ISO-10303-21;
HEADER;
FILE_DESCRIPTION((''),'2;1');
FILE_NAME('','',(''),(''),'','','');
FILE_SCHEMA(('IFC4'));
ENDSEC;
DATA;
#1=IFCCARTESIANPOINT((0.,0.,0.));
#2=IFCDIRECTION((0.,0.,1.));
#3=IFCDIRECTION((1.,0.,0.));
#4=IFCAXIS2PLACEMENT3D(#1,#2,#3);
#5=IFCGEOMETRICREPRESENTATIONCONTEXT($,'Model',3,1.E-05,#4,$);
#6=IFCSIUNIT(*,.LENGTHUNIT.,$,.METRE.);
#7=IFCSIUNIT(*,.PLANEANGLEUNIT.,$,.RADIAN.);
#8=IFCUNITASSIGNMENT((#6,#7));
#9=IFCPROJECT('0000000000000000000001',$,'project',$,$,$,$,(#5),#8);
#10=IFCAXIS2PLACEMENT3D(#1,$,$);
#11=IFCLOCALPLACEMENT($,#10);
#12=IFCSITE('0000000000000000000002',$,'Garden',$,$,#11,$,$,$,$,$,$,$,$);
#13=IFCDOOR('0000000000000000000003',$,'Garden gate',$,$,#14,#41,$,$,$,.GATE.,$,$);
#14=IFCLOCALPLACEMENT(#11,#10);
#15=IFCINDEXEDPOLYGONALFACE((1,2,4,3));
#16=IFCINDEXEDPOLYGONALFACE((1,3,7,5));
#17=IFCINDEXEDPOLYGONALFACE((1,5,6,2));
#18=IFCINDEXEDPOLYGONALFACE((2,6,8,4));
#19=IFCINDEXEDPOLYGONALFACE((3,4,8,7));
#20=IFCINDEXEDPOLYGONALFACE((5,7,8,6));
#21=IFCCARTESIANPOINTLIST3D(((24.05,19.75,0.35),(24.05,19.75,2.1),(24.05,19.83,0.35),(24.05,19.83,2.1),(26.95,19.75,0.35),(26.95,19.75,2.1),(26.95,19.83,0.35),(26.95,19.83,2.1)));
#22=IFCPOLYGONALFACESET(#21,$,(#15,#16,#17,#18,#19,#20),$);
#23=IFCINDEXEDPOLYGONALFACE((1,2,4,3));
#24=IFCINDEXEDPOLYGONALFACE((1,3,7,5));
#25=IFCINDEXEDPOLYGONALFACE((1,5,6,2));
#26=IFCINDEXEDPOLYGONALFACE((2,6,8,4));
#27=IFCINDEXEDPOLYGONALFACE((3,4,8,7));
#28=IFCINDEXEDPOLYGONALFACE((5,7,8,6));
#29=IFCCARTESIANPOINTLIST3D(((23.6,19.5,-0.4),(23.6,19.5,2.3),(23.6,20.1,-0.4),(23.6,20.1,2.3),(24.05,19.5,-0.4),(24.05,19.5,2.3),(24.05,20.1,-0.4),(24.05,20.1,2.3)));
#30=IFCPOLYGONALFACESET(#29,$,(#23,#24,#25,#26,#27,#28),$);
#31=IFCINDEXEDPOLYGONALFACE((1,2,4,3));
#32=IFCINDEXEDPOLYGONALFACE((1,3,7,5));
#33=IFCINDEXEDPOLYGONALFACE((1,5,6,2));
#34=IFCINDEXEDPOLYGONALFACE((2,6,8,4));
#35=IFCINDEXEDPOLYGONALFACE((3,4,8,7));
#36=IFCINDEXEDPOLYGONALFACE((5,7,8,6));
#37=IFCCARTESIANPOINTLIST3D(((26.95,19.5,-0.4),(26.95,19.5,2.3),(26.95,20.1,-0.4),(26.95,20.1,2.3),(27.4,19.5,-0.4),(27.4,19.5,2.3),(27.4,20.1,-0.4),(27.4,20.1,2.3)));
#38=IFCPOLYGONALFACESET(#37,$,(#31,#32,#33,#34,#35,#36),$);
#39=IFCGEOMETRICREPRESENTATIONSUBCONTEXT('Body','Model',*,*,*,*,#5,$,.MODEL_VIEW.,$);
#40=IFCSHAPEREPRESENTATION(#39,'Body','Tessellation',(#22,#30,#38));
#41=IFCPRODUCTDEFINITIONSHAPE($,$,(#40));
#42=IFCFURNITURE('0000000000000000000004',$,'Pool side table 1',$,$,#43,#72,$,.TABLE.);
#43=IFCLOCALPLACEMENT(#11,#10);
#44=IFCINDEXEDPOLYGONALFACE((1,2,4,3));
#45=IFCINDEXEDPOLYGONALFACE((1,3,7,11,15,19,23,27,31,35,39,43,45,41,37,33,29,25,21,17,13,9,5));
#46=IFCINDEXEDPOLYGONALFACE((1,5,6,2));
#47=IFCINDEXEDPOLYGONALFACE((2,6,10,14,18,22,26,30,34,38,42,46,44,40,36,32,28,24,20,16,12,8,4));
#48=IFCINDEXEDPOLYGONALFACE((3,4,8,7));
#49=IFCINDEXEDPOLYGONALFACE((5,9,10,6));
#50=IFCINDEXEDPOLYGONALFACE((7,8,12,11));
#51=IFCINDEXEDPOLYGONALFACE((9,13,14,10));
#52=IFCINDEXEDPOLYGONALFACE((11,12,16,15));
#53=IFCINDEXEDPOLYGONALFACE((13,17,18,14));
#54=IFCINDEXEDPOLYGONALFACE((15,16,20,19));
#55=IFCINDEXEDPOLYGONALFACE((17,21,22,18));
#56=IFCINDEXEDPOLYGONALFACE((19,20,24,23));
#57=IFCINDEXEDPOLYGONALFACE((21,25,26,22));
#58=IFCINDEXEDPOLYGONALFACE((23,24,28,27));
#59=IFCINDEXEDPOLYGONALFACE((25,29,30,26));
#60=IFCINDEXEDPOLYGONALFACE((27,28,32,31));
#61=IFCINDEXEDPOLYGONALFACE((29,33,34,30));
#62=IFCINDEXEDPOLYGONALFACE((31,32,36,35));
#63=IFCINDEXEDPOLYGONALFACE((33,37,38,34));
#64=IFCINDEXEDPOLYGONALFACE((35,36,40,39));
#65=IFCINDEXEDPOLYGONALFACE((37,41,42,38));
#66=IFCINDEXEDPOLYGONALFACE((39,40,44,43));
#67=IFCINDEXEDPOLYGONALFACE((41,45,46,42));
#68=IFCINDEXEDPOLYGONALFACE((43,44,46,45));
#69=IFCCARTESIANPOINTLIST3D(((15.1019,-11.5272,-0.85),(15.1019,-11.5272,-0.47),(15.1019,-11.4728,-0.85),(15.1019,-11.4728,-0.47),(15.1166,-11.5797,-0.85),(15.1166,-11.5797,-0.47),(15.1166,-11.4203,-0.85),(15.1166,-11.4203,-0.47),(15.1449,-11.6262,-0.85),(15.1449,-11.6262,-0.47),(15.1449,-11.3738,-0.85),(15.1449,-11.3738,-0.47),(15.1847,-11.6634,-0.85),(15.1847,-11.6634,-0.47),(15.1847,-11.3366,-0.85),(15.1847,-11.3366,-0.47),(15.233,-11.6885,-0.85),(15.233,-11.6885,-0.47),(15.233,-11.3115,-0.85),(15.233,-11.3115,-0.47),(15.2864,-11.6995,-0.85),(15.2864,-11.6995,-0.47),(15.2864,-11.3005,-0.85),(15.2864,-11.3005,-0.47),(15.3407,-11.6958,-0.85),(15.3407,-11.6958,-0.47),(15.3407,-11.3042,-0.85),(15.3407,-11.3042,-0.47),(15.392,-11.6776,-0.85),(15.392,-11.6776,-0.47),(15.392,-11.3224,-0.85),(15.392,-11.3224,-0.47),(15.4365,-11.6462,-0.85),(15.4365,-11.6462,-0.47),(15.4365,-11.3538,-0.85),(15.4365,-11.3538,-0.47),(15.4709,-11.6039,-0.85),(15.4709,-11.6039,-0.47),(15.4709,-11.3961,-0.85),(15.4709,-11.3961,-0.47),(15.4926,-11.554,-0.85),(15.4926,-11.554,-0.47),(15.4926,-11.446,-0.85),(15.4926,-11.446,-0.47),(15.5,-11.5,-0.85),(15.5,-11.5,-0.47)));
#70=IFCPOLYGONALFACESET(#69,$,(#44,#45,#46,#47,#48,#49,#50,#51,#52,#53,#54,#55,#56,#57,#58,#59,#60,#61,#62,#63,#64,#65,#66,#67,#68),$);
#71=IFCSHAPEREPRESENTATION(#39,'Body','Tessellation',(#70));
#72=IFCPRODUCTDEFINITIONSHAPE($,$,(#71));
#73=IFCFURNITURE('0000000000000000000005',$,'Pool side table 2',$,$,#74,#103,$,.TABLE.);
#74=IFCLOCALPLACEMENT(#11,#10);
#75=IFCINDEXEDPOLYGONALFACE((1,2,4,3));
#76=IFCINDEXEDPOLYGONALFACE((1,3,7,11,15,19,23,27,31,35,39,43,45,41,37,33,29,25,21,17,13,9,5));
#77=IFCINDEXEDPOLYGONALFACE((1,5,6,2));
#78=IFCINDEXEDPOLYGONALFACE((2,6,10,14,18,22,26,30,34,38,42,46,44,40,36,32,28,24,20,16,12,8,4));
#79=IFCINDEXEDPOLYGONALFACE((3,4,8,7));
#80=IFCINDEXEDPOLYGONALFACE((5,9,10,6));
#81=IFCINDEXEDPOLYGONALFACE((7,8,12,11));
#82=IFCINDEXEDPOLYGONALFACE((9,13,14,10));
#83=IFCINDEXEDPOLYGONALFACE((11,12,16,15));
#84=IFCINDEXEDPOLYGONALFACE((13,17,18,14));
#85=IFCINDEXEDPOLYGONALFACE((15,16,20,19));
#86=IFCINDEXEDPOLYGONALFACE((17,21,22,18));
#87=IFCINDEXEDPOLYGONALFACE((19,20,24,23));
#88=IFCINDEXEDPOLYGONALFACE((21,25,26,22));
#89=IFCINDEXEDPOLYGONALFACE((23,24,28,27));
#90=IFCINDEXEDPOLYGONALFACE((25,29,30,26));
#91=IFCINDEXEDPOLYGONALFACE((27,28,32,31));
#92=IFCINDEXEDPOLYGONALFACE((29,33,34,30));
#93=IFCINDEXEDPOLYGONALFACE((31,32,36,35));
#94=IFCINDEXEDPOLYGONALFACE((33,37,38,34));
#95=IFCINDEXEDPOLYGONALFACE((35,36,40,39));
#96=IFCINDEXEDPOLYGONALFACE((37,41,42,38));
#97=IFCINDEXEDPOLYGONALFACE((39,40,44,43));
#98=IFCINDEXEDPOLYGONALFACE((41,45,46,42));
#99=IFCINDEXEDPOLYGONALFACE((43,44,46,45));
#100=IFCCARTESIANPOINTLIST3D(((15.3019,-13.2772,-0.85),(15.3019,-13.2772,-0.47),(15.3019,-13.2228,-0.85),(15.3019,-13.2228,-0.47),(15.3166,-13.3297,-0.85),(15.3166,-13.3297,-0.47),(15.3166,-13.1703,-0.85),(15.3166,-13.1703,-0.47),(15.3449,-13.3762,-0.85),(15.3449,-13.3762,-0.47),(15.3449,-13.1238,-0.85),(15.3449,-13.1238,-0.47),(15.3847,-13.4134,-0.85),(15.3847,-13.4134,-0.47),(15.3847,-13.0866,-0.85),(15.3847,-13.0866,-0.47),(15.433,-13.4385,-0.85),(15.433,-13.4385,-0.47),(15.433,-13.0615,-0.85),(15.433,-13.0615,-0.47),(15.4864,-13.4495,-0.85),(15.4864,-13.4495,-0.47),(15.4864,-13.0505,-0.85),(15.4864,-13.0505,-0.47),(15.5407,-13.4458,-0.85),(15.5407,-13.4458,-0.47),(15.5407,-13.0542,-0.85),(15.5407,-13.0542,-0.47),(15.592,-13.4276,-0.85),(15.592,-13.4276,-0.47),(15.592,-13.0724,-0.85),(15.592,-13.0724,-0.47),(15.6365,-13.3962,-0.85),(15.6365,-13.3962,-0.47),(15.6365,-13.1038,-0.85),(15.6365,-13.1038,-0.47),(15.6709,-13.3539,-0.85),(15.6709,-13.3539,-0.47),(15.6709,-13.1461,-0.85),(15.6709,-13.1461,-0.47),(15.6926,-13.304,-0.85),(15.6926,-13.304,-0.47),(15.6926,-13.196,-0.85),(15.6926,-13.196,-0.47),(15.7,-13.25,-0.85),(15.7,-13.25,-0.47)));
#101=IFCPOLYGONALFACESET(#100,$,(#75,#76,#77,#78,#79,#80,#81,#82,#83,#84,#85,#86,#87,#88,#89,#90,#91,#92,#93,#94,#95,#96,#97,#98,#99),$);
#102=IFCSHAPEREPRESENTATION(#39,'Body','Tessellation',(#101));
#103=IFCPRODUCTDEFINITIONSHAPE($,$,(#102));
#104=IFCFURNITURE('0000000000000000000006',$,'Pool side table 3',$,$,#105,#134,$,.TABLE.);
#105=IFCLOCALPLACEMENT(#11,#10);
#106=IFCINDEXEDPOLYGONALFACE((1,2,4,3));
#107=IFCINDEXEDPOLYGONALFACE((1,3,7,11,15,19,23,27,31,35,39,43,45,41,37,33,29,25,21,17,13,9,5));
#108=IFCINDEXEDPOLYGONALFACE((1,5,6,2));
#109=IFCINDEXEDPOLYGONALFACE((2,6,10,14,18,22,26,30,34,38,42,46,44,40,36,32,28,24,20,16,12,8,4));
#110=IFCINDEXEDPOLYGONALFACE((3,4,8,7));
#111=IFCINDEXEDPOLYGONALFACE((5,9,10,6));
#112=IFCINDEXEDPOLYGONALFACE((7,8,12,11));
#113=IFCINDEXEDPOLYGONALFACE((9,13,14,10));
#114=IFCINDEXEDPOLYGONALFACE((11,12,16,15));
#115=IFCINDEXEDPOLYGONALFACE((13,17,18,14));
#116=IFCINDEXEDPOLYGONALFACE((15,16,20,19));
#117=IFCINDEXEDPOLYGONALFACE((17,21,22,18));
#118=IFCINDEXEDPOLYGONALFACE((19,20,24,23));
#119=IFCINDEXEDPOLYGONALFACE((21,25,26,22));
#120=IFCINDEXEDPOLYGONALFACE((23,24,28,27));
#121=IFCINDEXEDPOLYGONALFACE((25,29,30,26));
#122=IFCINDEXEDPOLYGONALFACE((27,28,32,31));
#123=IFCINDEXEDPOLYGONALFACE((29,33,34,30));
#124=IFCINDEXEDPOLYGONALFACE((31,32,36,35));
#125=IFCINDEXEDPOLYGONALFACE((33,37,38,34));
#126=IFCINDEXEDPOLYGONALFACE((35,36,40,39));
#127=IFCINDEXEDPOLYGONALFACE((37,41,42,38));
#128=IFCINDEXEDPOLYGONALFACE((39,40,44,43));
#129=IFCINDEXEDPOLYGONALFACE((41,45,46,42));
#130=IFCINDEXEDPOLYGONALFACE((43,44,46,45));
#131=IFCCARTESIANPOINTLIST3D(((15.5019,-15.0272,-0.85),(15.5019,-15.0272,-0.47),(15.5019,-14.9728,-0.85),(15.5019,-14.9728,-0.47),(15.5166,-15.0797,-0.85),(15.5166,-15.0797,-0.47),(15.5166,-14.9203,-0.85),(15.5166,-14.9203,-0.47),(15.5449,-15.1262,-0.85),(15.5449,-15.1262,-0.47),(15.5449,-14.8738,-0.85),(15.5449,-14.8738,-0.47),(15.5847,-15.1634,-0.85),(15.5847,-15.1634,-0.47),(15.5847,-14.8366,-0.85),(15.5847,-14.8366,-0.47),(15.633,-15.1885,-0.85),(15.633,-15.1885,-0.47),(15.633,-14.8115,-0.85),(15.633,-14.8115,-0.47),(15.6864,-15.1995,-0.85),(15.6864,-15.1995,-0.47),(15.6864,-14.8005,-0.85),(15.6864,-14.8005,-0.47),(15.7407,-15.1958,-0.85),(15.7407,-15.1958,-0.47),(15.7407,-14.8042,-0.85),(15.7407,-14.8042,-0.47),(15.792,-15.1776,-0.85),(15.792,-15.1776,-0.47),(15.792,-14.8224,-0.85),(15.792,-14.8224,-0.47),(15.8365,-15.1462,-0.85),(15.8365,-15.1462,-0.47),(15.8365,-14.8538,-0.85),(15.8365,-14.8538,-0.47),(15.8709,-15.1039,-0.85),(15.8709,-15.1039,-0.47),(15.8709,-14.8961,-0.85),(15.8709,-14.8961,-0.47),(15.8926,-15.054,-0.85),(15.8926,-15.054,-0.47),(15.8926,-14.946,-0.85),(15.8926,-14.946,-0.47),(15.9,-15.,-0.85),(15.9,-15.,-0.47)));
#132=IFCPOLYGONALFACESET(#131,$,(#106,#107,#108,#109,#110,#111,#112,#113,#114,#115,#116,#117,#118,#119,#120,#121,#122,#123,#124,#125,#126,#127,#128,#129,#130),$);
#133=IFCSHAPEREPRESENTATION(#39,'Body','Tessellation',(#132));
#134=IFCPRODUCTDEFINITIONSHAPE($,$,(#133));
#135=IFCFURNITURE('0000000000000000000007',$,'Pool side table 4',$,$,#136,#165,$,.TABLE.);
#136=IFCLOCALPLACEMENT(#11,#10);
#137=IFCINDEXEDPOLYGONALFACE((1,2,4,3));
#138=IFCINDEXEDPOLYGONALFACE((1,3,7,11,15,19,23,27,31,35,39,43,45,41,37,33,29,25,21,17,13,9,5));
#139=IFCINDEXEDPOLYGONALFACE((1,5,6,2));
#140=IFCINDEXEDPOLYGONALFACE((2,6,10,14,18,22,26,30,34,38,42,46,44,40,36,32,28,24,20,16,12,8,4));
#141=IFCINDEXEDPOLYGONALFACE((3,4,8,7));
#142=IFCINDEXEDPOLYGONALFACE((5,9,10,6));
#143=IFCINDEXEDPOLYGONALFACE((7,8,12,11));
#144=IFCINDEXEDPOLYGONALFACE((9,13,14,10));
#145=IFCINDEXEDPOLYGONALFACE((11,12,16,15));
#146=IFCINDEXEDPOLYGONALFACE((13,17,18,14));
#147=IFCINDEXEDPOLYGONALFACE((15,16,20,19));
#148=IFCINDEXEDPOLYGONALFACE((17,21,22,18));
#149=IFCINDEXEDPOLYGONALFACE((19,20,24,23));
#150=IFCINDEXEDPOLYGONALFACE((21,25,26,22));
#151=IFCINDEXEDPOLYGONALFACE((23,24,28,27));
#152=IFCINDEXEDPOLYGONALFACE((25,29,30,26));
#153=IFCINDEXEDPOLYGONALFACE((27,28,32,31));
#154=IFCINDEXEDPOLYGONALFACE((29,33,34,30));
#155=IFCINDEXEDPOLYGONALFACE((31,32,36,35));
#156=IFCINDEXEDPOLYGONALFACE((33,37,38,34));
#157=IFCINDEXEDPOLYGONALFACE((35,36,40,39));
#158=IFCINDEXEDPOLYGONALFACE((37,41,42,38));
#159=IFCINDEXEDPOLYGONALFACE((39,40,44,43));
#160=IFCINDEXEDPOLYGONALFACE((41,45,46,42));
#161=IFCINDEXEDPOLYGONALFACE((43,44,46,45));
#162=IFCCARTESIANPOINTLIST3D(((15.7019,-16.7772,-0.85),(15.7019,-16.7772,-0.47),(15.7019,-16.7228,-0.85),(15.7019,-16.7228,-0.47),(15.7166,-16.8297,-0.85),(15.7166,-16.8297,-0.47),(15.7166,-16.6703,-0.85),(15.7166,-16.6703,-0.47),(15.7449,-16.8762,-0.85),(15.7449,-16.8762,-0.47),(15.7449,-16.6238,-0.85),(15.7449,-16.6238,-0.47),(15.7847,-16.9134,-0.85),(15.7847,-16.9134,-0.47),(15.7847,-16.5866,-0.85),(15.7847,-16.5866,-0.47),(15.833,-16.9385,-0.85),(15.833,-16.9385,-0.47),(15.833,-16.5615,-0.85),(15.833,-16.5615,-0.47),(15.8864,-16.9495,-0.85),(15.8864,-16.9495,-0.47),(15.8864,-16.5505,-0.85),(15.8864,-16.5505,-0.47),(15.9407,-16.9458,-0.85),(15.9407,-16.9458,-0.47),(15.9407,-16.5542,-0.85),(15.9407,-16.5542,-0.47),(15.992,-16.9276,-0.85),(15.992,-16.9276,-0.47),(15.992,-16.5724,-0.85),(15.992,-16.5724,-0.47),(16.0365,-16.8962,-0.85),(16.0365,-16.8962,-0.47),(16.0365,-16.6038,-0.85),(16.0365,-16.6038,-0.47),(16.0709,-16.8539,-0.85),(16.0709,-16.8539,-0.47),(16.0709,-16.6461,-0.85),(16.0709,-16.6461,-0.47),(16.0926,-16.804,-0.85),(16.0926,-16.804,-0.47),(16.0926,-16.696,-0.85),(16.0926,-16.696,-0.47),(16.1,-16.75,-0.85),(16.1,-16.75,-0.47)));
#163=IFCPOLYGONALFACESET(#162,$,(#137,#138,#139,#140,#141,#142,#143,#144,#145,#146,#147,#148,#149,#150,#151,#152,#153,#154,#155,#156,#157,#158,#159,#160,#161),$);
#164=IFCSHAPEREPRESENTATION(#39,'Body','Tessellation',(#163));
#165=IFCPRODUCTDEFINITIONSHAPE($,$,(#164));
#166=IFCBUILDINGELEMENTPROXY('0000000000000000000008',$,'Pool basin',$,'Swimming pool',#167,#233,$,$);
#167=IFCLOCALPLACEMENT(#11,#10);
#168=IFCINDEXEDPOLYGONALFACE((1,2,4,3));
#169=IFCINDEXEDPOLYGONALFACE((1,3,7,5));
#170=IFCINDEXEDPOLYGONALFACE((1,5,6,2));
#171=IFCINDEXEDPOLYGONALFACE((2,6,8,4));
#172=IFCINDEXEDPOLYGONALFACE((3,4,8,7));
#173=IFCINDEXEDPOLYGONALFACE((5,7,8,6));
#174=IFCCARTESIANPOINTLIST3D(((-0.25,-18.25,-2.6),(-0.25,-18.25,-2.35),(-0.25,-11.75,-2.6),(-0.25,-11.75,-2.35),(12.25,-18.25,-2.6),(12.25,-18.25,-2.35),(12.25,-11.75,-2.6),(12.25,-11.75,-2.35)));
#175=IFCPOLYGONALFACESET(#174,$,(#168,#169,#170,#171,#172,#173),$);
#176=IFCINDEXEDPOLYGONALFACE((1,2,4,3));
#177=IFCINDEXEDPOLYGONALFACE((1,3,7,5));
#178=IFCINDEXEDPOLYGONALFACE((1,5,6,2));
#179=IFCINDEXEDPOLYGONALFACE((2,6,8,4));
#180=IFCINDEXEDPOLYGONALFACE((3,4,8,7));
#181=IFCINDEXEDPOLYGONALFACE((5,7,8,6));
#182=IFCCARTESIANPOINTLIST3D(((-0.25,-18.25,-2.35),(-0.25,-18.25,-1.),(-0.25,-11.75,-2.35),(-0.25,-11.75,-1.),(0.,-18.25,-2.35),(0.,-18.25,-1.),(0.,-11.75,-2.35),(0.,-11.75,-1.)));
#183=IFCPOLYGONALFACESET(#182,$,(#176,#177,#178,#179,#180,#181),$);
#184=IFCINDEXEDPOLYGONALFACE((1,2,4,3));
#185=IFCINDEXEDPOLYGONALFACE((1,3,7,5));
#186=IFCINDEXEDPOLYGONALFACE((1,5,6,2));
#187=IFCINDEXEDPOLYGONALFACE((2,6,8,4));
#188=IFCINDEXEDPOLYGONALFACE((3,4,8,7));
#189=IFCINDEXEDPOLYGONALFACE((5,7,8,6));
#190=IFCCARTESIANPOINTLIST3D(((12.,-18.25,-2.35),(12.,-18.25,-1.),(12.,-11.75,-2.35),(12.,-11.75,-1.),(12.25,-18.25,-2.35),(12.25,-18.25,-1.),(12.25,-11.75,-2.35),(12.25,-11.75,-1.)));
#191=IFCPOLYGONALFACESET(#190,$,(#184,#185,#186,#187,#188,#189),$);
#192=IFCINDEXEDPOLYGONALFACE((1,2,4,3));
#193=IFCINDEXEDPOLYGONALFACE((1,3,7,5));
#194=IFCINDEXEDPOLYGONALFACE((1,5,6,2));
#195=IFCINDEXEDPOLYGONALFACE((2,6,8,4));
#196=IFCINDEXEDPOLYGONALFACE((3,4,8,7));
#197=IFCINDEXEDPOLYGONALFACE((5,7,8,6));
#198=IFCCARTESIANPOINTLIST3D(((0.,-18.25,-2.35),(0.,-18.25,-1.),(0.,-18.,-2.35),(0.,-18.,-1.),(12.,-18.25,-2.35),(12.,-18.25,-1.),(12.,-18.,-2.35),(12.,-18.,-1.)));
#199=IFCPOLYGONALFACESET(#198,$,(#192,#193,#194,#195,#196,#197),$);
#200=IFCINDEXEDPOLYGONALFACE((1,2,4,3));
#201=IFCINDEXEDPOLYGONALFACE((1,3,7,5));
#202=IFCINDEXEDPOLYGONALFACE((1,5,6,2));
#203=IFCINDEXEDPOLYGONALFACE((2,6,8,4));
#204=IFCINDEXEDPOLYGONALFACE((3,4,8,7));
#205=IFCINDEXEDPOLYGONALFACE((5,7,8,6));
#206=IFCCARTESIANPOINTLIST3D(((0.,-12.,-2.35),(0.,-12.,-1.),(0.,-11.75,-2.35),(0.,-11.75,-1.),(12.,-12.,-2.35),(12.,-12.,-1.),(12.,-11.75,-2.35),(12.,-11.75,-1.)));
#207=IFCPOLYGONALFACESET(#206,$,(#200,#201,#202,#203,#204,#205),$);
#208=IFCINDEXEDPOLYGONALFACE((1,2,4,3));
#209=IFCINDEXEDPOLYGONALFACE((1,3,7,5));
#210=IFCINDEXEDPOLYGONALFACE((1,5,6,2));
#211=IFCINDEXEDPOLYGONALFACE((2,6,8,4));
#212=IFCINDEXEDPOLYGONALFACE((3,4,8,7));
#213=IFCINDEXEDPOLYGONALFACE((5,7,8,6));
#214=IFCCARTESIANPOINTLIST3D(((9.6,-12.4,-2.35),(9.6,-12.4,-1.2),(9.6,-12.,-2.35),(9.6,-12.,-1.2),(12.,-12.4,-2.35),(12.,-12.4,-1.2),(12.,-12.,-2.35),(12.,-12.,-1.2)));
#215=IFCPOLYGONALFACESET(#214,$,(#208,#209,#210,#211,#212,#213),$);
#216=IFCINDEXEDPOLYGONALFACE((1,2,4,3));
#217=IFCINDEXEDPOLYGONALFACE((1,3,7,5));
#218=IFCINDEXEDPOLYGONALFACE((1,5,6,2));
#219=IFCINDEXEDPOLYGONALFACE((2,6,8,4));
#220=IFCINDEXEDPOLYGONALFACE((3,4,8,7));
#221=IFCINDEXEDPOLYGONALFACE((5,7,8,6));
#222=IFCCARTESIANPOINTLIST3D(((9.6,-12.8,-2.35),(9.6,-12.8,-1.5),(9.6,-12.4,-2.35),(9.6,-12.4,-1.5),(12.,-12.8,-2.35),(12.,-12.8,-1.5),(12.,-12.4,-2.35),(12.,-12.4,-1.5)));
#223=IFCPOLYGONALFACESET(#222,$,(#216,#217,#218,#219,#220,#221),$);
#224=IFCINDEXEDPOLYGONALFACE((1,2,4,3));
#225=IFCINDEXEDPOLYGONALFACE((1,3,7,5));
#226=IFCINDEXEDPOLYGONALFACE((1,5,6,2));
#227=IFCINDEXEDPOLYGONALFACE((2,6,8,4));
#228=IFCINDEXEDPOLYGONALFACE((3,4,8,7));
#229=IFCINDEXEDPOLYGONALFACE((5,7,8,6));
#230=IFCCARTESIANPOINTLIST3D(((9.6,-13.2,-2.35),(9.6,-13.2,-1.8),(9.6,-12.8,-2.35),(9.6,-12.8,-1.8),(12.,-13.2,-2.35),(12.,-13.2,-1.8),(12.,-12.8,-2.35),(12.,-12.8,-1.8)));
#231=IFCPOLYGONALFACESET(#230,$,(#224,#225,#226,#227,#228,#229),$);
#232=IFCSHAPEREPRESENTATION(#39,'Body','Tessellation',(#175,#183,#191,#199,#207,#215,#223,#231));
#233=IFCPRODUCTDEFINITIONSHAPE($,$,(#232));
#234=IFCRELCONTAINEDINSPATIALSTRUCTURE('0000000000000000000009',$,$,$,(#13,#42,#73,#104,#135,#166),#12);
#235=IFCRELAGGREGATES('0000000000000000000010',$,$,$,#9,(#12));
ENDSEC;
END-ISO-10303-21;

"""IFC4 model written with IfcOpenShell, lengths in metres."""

from ifc_helpers import new_model, si_unit, frame, frame_2d, origin, origin_with_axes, origin_2d, place, context, subcontext, project, spatial, rectangle, circle, extrude, element, save


model = new_model("IFC4")

# Units and contexts
model_context = context("Model", 3, precision=1e-05, world=origin_with_axes())
body_context = subcontext(model_context, "Body", "Model", "MODEL_VIEW")
ifc_project = project(units=[si_unit("LENGTHUNIT", "METRE"), si_unit("PLANEANGLEUNIT", "RADIAN")], contexts=[model_context])

# Site
site_placement = place(None, origin())
site = spatial("IfcSite", under=ifc_project, at=site_placement, Name="Garden")

# Door
door_placement = place(site_placement, origin())
element("IfcDoor", 1, at=door_placement, inside=site, Name="Garden gate", PredefinedType="GATE", context=body_context, shape_type="SweptSolid", body=[
    extrude(rectangle(XDim=2.9, YDim=0.08, at=frame_2d((1.45, 0.04))), frame((24.05, 19.75, 0.35)), (0.0, 0.0, 1.0), 1.75),
    extrude(rectangle(XDim=0.45, YDim=0.6, at=frame_2d((0.225, 0.3))), frame((23.6, 19.5, -0.4)), (0.0, 0.0, 1.0), 2.7),
    extrude(rectangle(XDim=0.45, YDim=0.6, at=frame_2d((0.225, 0.3))), frame((26.95, 19.5, -0.4)), (0.0, 0.0, 1.0), 2.7),
])

# Furniture
for number, where, name in (
    (2, (15.3, -11.5, -0.85), "Pool side table 1"),
    (3, (15.5, -13.25, -0.85), "Pool side table 2"),
    (4, (15.7, -15.0, -0.85), "Pool side table 3"),
    (5, (15.9, -16.75, -0.85), "Pool side table 4"),
):
    element("IfcFurniture", number, at=place(site_placement, frame(where)), inside=site, Name=name, PredefinedType="TABLE", context=body_context, shape_type="SweptSolid", body=[
        extrude(circle(Radius=0.2, at=origin_2d()), origin(), (0.0, 0.0, 1.0), 0.38),
    ])

# Building element proxy
proxy_1_placement = place(site_placement, origin())
element("IfcBuildingElementProxy", 6, at=proxy_1_placement, inside=site, Name="Pool basin", ObjectType="Swimming pool", context=body_context, shape_type="SweptSolid", body=[
    extrude(rectangle(XDim=12.5, YDim=6.5, at=frame_2d((6.25, 3.25))), frame((-0.25, -18.25, -2.6)), (0.0, 0.0, 1.0), 0.25),
    extrude(rectangle(XDim=0.25, YDim=6.5, at=frame_2d((0.125, 3.25))), frame((-0.25, -18.25, -2.35)), (0.0, 0.0, 1.0), 1.35),
    extrude(rectangle(XDim=0.25, YDim=6.5, at=frame_2d((0.125, 3.25))), frame((12.0, -18.25, -2.35)), (0.0, 0.0, 1.0), 1.35),
    extrude(rectangle(XDim=12.0, YDim=0.25, at=frame_2d((6.0, 0.125))), frame((0.0, -18.25, -2.35)), (0.0, 0.0, 1.0), 1.35),
    extrude(rectangle(XDim=12.0, YDim=0.25, at=frame_2d((6.0, 0.125))), frame((0.0, -12.0, -2.35)), (0.0, 0.0, 1.0), 1.35),
    extrude(rectangle(XDim=2.4, YDim=0.4, at=frame_2d((1.2, 0.2))), frame((9.6, -12.4, -2.35)), (0.0, 0.0, 1.0), 1.15),
    extrude(rectangle(XDim=2.4, YDim=0.4, at=frame_2d((1.2, 0.2))), frame((9.6, -12.8, -2.35)), (0.0, 0.0, 1.0), 0.85),
    extrude(rectangle(XDim=2.4, YDim=0.4, at=frame_2d((1.2, 0.2))), frame((9.6, -13.2, -2.35)), (0.0, 0.0, 1.0), 0.55),
])

save(model, "model.ifc")
